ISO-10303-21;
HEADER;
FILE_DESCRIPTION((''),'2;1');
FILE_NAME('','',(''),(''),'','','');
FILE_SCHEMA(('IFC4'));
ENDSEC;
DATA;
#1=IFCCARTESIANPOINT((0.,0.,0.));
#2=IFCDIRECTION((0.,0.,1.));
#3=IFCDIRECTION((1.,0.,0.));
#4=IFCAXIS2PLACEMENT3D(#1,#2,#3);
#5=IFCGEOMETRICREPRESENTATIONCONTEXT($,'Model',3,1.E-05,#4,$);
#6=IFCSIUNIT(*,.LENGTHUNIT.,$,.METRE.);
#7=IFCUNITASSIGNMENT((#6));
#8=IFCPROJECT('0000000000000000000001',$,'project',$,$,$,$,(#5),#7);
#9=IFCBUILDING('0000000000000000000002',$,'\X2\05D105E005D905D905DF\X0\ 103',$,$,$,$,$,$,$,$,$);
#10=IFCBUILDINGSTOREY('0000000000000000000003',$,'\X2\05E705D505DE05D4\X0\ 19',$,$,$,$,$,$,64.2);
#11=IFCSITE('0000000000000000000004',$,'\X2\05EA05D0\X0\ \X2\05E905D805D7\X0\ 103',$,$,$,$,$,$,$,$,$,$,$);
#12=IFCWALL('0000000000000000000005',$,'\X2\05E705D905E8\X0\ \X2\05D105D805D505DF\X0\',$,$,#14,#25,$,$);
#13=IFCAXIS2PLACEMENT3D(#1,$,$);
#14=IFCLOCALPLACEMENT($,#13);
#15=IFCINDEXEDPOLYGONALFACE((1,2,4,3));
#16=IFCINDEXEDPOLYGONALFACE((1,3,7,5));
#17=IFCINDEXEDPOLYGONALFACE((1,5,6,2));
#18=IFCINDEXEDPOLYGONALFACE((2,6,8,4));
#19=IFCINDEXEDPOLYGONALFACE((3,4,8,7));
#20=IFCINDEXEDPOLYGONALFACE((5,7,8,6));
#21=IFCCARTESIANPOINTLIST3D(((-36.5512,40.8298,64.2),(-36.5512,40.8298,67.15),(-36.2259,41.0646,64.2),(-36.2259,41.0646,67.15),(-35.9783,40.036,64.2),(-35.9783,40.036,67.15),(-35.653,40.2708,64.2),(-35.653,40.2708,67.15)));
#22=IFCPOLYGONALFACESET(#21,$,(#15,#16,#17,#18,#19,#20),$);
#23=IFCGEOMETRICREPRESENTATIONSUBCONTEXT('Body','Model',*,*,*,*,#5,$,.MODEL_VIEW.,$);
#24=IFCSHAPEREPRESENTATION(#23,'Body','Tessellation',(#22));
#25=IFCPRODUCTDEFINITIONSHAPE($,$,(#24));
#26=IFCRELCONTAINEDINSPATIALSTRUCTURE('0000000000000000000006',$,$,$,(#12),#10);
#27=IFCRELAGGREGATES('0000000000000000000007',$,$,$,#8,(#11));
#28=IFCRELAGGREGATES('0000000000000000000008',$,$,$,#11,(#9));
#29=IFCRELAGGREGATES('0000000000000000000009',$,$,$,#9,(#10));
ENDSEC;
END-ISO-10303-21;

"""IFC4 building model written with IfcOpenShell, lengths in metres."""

from ifc_helpers import new_model, si_unit, frame, origin_with_axes, context, subcontext, project, spatial, polyline, outline, extrude, element, save


model = new_model("IFC4")

# Units and contexts
model_context = context("Model", 3, precision=1e-05, world=origin_with_axes())
body_context = subcontext(model_context, "Body", "Model", "MODEL_VIEW")
ifc_project = project(units=[si_unit("LENGTHUNIT", "METRE")], contexts=[model_context])

# Site, building, storey
site = spatial("IfcSite", under=ifc_project, Name="תא שטח 103")
building = spatial("IfcBuilding", under=site, Name="בניין 103")
storey = spatial("IfcBuildingStorey", under=building, Name="קומה 19", Elevation=64.2)

# Wall
element("IfcWall", 1, inside=storey, Name="קיר בטון", context=body_context, shape_type="SweptSolid", body=[
    extrude(outline(polyline([(-36.2259, 41.0646), (-35.653, 40.2708), (-35.9783, 40.036), (-36.5512, 40.8298), (-36.2259, 41.0646)])), frame((0.0, 0.0, 64.2)), (0.0, 0.0, 1.0), 2.95),
])

save(model, "model.ifc")
